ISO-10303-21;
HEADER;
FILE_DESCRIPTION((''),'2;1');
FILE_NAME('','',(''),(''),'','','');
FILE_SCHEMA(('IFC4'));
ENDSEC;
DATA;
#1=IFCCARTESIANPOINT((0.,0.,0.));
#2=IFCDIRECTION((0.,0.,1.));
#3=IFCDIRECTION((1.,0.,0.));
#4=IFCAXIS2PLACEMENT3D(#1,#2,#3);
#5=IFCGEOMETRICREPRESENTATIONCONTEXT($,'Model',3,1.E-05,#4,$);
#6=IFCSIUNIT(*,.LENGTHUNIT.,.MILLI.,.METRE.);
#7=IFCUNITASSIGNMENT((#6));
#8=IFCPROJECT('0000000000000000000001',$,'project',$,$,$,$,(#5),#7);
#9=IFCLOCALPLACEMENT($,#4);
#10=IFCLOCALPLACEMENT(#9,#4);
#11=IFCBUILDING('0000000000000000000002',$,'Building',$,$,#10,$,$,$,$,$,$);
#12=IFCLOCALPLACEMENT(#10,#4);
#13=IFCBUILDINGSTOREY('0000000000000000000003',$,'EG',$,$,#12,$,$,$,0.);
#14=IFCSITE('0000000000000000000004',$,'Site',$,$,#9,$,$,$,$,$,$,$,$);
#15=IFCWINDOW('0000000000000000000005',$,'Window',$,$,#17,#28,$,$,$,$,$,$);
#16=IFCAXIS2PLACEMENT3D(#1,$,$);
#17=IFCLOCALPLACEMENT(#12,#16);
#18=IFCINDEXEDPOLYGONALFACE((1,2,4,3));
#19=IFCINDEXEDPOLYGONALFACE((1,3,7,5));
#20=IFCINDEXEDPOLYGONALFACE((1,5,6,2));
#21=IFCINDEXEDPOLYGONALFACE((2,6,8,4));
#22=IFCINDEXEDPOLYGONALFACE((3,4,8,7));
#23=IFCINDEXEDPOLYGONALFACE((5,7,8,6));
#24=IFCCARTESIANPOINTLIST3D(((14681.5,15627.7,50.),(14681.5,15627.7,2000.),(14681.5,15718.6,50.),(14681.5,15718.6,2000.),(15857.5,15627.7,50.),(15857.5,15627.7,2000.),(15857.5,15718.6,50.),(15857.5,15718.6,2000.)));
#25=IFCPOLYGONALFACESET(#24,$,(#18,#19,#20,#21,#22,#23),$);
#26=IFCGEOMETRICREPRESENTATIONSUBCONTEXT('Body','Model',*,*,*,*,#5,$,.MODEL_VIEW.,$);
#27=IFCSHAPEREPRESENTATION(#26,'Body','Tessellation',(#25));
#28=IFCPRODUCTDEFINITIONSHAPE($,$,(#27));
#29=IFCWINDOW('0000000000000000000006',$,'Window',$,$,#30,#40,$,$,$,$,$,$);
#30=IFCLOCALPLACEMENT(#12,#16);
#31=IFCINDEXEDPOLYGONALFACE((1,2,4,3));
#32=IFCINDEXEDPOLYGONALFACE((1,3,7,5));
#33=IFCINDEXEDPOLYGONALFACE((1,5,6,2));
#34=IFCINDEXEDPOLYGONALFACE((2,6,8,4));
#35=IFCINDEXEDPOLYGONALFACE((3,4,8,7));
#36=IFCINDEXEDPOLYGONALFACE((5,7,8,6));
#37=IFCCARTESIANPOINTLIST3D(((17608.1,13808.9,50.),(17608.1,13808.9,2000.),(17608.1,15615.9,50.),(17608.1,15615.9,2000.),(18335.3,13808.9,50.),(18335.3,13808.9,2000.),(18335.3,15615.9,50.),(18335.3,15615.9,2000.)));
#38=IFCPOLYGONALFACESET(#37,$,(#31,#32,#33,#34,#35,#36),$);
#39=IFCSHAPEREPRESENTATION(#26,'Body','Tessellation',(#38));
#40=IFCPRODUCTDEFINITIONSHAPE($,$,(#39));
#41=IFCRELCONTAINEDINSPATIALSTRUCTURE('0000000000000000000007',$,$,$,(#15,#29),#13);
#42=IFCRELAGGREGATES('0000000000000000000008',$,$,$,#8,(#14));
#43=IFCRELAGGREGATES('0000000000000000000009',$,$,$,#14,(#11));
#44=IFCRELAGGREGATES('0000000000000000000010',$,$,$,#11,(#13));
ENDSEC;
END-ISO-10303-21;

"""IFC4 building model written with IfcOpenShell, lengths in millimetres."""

from ifc_helpers import new_model, si_unit, frame, origin_with_axes, place, context, subcontext, project, spatial, rectangle, extrude, element, save


model = new_model("IFC4")

# Units and contexts
model_context = context("Model", 3, precision=1e-05, world=origin_with_axes())
body_context = subcontext(model_context, "Body", "Model", "MODEL_VIEW")
ifc_project = project(units=[si_unit("LENGTHUNIT", "METRE", prefix="MILLI")], contexts=[model_context])

# Site, building, storey
site_placement = place(None, origin_with_axes())
site = spatial("IfcSite", under=ifc_project, at=site_placement, Name="Site")
building_placement = place(site_placement, origin_with_axes())
building = spatial("IfcBuilding", under=site, at=building_placement, Name="Building")
storey_placement = place(building_placement, origin_with_axes())
storey = spatial("IfcBuildingStorey", under=building, at=storey_placement, Name="EG", Elevation=0.0)

# Windows
window_1_placement = place(storey_placement, origin_with_axes())
element("IfcWindow", 1, at=window_1_placement, inside=storey, Name="Window", context=body_context, shape_type="SweptSolid", body=[
    extrude(rectangle(XDim=1176.0, YDim=90.9), frame((15269.5, 15673.2, 50.0), z_axis=(0.0, 0.0, 1.0), x_axis=(1.0, 0.0, 0.0)), (0.0, 0.0, 1.0), 1950.0),
])
window_2_placement = place(storey_placement, origin_with_axes())
element("IfcWindow", 2, at=window_2_placement, inside=storey, Name="Window", context=body_context, shape_type="SweptSolid", body=[
    extrude(rectangle(XDim=1807.0, YDim=727.2), frame((17971.7, 14712.4, 50.0), z_axis=(0.0, 0.0, 1.0), x_axis=(0.0, 1.0, 0.0)), (0.0, 0.0, 1.0), 1950.0),
])

save(model, "model.ifc")
